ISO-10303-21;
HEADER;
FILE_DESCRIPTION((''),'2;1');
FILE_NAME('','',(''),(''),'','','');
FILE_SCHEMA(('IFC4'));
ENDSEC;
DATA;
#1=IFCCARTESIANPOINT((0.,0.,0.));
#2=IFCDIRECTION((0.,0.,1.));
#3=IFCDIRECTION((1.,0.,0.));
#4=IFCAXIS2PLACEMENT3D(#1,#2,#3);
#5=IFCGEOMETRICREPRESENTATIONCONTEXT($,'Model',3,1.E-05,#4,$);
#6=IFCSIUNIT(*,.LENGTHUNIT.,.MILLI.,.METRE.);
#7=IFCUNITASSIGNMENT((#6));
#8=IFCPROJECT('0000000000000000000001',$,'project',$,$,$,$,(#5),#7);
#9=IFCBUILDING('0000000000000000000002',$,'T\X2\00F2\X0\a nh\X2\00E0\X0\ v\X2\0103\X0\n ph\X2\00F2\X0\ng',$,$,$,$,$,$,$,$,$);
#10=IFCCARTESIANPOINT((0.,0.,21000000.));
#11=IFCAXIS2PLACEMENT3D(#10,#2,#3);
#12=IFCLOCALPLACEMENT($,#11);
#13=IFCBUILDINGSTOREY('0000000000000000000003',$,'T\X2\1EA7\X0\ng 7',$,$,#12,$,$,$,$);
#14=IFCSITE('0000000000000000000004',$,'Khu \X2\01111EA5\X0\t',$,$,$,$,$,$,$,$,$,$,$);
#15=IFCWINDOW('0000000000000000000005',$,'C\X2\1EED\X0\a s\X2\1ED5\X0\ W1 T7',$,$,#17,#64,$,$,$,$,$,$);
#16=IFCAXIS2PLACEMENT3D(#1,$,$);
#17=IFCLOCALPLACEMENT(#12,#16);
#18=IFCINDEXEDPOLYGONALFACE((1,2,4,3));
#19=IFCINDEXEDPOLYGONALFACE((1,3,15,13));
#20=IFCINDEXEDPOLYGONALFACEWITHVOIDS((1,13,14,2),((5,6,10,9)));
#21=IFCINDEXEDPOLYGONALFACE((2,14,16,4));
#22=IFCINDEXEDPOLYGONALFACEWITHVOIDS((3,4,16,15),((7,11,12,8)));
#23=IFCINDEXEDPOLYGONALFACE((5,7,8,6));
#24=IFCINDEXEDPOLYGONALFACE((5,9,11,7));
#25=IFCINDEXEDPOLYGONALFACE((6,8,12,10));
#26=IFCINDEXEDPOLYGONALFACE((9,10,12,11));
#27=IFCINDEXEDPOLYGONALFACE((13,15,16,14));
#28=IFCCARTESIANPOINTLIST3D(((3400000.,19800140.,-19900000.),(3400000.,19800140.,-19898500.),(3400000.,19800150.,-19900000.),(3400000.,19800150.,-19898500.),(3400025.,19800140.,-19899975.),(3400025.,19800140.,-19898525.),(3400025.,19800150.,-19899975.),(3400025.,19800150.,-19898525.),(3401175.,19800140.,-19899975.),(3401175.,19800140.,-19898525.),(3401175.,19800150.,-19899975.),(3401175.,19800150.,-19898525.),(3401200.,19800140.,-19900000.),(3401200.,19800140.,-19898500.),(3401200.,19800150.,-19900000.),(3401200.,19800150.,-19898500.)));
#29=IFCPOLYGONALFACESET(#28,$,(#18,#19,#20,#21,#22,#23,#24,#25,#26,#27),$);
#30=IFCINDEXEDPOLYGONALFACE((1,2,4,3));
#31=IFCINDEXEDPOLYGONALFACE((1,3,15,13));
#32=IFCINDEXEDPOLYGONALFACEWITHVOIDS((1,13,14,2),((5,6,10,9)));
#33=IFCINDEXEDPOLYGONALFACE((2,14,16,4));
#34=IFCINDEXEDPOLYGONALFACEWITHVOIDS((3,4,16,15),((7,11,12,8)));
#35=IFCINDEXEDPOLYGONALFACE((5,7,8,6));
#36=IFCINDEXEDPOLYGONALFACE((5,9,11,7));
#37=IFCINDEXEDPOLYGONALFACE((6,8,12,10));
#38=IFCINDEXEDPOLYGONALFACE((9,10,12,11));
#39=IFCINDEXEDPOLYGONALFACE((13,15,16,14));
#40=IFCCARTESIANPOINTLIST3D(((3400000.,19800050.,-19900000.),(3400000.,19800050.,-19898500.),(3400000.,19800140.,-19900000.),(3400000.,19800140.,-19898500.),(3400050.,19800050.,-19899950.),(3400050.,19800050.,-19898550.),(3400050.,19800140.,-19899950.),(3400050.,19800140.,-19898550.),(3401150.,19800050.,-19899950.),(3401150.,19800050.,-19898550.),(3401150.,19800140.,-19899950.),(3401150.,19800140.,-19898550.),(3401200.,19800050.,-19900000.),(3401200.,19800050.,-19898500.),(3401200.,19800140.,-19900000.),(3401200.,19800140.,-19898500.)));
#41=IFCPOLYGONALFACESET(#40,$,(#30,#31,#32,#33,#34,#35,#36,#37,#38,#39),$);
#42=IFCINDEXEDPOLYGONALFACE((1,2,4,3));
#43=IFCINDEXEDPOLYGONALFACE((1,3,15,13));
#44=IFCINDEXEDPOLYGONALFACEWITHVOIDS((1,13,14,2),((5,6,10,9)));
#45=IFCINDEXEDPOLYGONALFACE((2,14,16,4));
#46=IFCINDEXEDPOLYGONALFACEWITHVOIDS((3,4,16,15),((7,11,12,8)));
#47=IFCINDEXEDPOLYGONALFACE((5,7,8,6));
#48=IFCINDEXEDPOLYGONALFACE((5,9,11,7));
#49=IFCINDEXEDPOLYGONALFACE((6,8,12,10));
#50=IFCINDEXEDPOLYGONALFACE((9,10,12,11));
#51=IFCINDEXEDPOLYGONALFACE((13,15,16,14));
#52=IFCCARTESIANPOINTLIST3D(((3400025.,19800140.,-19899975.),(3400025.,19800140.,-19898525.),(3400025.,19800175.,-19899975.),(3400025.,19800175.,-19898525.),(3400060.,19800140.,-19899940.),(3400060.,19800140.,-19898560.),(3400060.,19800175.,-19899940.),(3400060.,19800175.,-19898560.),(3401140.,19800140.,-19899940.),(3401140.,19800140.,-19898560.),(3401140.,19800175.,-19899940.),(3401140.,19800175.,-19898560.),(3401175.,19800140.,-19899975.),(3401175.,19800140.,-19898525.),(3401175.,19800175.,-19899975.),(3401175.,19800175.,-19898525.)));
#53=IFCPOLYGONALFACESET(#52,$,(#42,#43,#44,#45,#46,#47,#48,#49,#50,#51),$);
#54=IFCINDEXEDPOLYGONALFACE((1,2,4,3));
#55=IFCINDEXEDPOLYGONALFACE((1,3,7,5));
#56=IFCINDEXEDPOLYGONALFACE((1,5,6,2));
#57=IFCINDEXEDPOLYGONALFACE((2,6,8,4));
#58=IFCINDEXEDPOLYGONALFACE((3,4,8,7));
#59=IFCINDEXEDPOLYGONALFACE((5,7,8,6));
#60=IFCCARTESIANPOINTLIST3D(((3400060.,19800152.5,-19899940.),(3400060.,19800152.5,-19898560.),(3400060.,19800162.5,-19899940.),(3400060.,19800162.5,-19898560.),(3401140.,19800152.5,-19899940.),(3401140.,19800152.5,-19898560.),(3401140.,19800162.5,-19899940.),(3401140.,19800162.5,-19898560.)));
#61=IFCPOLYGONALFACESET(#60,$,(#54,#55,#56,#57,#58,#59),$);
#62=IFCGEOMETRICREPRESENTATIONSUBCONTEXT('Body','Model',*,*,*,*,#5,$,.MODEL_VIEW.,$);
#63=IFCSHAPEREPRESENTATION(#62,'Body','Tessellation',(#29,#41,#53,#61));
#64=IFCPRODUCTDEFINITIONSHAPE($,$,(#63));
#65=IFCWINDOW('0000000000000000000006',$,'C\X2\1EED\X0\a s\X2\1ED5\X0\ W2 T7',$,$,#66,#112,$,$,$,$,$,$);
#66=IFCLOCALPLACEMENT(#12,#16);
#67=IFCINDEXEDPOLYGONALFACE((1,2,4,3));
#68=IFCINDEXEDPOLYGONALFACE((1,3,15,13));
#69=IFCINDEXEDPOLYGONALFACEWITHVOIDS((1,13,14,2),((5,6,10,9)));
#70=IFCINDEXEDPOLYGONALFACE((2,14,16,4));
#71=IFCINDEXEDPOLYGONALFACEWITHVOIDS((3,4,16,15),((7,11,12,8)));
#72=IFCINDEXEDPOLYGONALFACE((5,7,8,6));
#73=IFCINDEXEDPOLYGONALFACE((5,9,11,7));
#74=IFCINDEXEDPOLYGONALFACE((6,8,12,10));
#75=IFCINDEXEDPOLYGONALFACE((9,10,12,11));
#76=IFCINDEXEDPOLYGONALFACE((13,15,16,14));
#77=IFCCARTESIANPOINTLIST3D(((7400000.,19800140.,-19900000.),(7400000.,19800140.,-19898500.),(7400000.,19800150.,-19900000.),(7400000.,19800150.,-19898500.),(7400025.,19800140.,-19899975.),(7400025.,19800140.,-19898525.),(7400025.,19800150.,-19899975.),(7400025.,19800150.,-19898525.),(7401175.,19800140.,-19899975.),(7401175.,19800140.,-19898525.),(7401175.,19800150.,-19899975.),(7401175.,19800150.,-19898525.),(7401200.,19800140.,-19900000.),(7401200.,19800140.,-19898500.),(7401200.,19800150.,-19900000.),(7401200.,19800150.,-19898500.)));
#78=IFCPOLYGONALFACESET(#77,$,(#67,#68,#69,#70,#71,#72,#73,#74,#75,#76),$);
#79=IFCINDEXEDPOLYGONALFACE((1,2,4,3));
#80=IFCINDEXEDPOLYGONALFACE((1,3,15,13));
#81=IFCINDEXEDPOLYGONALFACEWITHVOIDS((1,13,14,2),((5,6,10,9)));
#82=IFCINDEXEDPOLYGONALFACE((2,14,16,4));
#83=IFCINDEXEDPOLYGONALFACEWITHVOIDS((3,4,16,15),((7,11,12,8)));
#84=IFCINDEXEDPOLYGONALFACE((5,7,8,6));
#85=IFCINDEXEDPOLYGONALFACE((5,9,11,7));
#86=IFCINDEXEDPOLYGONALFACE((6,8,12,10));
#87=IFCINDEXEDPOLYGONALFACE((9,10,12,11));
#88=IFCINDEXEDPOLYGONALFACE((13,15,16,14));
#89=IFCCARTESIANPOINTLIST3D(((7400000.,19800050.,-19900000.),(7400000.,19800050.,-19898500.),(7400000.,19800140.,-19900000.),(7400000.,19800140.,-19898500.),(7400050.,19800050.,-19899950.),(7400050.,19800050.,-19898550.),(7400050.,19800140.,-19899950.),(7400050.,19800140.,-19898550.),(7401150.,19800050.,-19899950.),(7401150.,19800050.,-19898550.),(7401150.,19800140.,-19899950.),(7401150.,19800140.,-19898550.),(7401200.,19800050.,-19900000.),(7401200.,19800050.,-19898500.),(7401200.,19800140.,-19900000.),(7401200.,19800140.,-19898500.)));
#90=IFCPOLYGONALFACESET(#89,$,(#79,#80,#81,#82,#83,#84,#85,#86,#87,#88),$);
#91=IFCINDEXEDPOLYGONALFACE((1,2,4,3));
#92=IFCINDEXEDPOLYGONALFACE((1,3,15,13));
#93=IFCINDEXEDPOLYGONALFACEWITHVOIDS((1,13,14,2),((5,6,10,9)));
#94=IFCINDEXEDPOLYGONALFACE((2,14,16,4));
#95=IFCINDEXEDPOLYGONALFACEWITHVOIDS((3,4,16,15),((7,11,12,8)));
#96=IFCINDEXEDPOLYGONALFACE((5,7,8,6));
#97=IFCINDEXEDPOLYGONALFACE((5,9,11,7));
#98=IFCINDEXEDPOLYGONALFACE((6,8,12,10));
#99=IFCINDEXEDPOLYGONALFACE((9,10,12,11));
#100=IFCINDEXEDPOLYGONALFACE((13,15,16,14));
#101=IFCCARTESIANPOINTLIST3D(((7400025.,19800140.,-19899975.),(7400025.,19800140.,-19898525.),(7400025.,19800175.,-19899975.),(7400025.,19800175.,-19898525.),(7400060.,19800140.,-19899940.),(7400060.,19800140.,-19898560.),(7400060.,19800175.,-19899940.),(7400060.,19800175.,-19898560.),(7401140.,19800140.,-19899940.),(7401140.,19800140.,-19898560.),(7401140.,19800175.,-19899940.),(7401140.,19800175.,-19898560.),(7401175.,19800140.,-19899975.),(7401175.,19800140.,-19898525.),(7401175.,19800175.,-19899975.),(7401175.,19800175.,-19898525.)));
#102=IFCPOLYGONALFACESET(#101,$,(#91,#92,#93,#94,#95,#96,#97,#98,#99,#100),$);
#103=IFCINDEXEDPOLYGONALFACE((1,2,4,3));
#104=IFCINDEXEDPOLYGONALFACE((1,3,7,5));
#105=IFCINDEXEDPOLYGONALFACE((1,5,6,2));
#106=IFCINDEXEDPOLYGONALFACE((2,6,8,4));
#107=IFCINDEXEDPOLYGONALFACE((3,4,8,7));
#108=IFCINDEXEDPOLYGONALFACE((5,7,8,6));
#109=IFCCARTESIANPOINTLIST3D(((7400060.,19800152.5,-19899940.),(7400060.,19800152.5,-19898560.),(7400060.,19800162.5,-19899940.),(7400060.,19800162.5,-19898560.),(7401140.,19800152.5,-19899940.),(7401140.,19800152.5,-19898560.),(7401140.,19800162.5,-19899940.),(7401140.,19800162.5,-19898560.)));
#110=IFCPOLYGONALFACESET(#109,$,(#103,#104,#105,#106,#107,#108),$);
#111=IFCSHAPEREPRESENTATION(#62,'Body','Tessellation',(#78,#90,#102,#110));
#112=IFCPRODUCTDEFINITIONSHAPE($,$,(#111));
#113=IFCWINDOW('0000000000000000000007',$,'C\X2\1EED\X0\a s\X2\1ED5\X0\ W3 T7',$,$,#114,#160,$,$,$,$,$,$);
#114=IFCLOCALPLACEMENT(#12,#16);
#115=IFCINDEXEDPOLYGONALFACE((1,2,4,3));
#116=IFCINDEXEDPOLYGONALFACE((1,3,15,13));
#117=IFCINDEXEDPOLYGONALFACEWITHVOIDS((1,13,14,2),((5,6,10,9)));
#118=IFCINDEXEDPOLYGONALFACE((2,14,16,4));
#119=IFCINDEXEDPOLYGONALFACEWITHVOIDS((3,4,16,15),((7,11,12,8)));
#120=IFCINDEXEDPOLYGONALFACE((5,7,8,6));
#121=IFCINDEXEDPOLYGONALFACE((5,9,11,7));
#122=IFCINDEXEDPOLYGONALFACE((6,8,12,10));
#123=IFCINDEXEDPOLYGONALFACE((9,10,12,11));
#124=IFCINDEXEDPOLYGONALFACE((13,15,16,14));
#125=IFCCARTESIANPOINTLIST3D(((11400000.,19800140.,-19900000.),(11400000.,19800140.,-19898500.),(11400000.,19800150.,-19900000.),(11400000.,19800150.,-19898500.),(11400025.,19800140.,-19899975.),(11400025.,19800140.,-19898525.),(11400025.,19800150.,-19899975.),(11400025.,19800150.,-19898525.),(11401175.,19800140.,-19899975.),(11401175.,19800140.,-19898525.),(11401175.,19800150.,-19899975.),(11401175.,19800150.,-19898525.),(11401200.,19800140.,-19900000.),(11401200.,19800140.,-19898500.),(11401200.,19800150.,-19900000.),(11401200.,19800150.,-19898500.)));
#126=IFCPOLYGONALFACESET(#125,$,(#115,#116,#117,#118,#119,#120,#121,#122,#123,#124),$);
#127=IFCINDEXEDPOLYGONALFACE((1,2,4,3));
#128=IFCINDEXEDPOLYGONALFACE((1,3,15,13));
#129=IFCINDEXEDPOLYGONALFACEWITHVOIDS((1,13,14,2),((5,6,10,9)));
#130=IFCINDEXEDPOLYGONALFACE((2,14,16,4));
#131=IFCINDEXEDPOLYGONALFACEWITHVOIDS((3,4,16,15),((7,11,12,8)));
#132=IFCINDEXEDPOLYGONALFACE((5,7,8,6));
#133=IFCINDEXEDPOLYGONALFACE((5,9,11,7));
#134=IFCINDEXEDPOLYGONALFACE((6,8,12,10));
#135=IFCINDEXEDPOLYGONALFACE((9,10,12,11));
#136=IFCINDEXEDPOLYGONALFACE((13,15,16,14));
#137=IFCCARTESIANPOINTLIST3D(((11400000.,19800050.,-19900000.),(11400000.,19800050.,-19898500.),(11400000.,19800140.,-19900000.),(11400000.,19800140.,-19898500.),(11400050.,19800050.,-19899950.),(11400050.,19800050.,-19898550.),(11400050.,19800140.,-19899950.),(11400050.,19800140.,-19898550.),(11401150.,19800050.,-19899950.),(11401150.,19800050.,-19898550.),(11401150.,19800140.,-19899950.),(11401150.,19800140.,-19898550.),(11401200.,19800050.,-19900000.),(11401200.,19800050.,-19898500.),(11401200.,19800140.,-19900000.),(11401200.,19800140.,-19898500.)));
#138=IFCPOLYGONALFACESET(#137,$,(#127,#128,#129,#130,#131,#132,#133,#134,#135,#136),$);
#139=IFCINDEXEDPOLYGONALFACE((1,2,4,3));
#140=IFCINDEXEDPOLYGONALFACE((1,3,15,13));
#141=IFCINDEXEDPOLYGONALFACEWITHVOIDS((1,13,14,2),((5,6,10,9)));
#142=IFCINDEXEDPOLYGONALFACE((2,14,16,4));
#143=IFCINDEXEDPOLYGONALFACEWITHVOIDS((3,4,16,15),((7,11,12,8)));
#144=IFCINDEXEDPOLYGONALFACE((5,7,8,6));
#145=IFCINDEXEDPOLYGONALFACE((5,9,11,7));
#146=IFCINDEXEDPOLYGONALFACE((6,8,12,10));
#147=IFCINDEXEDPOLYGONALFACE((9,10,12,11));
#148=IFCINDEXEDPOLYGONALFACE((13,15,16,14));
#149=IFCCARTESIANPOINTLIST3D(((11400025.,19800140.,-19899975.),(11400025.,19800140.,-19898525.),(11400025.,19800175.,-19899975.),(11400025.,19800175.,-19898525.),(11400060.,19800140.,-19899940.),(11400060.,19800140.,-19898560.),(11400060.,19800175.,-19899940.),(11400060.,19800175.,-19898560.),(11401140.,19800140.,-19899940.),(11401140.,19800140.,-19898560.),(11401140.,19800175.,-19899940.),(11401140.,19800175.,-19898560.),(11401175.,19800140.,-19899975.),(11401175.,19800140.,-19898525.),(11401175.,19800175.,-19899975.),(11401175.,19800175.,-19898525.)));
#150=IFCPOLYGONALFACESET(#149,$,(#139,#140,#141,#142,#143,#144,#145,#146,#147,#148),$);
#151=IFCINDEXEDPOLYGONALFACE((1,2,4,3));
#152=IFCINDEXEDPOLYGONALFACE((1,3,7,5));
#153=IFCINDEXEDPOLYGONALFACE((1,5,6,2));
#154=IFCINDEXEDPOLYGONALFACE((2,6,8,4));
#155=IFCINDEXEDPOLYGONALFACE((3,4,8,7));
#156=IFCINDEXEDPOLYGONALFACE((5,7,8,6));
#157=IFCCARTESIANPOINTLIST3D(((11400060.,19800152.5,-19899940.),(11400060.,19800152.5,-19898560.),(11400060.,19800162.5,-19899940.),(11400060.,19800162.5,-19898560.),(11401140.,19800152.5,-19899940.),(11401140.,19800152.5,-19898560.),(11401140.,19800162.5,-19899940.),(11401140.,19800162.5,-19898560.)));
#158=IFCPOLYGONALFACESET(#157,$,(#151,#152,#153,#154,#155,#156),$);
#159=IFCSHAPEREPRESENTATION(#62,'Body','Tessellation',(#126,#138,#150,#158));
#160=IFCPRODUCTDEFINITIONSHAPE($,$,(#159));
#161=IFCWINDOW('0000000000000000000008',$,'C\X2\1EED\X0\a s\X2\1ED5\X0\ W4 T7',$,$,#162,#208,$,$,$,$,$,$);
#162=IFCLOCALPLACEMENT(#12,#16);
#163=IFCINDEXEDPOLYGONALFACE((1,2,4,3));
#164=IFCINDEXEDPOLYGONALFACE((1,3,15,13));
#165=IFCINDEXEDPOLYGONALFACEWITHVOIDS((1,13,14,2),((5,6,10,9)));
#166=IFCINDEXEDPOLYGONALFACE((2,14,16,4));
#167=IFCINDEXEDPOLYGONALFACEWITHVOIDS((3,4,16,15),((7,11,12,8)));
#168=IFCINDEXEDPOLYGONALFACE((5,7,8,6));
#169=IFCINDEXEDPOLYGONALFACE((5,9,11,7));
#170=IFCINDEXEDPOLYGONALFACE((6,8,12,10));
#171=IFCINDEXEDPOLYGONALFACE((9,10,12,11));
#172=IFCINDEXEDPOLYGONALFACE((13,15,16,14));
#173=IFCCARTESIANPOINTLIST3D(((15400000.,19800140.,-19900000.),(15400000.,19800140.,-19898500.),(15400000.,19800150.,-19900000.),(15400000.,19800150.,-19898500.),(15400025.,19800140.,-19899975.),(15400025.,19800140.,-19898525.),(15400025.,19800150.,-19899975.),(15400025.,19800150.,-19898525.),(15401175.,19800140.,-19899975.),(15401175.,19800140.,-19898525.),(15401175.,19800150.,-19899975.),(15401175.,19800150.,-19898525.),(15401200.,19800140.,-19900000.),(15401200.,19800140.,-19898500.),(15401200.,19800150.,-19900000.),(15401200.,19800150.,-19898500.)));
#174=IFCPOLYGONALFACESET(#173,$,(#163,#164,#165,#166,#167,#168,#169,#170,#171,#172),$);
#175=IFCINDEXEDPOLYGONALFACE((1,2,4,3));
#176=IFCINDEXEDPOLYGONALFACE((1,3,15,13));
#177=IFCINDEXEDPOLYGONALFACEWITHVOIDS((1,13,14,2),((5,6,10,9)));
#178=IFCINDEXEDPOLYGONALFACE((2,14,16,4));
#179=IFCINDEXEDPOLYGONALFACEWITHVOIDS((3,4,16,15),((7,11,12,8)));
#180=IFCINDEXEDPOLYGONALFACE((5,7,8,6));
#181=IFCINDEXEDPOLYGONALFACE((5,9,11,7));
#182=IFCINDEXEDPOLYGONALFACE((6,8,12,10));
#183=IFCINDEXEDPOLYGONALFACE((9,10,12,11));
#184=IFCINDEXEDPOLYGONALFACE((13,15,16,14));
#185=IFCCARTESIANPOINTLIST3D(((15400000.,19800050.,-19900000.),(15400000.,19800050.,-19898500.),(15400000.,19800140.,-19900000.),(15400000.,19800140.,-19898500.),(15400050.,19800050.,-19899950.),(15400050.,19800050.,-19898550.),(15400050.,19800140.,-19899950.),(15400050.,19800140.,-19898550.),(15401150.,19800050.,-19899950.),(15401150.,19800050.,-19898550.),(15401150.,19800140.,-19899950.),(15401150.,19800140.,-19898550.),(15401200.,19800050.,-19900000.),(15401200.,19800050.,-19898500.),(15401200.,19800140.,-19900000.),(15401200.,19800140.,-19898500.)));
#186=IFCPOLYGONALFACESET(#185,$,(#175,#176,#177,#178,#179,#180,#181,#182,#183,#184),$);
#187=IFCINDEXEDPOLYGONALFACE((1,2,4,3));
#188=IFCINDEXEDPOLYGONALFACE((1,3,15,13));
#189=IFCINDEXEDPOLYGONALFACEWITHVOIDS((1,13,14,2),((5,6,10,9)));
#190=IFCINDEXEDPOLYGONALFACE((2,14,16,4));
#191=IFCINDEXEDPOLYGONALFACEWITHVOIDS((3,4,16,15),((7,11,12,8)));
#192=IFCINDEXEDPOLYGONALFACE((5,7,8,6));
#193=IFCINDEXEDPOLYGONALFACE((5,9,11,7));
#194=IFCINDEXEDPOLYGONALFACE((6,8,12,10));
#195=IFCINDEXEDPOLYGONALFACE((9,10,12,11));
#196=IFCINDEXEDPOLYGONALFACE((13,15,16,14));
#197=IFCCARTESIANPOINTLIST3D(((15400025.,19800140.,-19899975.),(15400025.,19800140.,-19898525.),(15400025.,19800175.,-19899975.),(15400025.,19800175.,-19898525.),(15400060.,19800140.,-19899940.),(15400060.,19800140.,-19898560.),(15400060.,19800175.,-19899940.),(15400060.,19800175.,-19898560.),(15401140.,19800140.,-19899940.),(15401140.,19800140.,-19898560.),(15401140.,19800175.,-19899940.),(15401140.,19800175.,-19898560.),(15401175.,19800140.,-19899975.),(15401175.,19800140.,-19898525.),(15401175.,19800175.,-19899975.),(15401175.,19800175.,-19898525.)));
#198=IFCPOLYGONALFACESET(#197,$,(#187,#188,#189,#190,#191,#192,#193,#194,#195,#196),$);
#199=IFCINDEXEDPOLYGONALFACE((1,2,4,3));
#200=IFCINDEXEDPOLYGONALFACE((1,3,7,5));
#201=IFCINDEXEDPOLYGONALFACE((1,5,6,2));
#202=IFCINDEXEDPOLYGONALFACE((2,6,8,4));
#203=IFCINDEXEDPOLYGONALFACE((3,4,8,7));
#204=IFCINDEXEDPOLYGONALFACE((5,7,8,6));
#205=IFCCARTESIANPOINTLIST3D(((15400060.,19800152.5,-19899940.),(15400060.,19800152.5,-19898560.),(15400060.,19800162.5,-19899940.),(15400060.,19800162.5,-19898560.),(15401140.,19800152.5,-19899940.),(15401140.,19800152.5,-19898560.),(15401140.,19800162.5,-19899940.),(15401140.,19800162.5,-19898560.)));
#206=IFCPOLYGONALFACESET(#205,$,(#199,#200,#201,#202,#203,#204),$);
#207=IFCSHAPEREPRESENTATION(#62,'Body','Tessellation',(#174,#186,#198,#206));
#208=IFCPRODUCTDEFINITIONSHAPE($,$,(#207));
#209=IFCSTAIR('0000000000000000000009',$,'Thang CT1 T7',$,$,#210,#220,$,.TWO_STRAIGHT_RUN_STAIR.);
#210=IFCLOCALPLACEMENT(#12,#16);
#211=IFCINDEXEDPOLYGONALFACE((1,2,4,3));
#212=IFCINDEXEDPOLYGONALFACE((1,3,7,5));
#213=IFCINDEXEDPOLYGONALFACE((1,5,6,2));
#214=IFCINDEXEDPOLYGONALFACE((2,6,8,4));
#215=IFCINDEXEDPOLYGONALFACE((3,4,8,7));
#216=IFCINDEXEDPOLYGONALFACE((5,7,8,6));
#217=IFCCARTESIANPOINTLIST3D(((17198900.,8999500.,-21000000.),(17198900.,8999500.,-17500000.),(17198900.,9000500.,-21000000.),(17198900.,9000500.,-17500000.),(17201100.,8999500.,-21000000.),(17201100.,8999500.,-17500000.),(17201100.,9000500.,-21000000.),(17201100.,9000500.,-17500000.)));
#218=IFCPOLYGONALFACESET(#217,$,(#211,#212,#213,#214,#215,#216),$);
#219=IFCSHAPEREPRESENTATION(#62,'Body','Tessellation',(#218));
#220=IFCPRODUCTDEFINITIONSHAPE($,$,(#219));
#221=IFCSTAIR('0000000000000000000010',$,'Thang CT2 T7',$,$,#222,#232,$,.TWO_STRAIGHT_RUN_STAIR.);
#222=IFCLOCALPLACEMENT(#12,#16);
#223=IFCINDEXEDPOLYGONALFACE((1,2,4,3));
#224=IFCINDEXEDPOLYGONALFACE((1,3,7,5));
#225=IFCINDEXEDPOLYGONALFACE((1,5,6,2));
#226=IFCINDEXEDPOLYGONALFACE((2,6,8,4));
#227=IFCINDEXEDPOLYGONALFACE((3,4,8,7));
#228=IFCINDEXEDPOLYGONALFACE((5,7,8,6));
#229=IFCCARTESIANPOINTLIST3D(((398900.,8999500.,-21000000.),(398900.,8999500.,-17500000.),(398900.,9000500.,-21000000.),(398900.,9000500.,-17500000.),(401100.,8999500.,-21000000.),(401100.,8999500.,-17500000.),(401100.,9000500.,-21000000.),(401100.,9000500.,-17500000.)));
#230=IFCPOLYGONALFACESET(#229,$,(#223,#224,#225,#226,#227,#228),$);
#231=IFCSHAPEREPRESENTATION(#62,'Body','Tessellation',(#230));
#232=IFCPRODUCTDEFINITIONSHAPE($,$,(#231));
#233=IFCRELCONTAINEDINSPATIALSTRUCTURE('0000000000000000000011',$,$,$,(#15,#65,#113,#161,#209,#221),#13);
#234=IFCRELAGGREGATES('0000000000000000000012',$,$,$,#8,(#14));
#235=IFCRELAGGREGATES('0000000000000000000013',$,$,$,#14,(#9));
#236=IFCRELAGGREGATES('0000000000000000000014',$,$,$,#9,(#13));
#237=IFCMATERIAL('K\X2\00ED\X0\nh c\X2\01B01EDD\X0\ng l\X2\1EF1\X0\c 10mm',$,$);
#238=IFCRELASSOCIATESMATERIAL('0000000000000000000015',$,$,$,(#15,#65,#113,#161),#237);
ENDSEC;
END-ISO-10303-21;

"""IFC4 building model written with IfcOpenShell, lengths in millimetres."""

from ifc_helpers import new_model, entity, si_unit, frame, origin_with_axes, place, context, subcontext, project, spatial, line, indexed_curve, outline, extrude, material, element, save


model = new_model("IFC4")

# Units and contexts
model_context = context("Model", 3, precision=1e-05, world=origin_with_axes())
body_context = subcontext(model_context, "Body", "Model", "MODEL_VIEW")
ifc_project = project(units=[si_unit("LENGTHUNIT", "METRE", prefix="MILLI")], contexts=[model_context])

# Site, building, storey
site = spatial("IfcSite", under=ifc_project, Name="Khu đất")
building = spatial("IfcBuilding", under=site, Name="Tòa nhà văn phòng")
storey_placement = place(None, frame((0.0, 0.0, 21000000.0), z_axis=(0.0, 0.0, 1.0), x_axis=(1.0, 0.0, 0.0)))
storey = spatial("IfcBuildingStorey", under=building, at=storey_placement, Name="Tầng 7")

# Windows
ifc_material_1 = material(Name="Kính cường lực 10mm")
for number, where, z_axis, x_axis, name in (
    (1, (3400000.0, 19800000.0, -19900000.0), (0.0, 0.0, 1.0), (1.0, 0.0, 0.0), "Cửa sổ W1 T7"),
    (2, (7400000.0, 19800000.0, -19900000.0), (0.0, 0.0, 1.0), (1.0, 0.0, 0.0), "Cửa sổ W2 T7"),
    (3, (11400000.0, 19800000.0, -19900000.0), (0.0, 0.0, 1.0), (1.0, 0.0, 0.0), "Cửa sổ W3 T7"),
    (4, (15400000.0, 19800000.0, -19900000.0), (0.0, 0.0, 1.0), (1.0, 0.0, 0.0), "Cửa sổ W4 T7"),
):
    element("IfcWindow", number, at=place(storey_placement, frame(where, z_axis=z_axis, x_axis=x_axis)), inside=storey, material=ifc_material_1, Name=name, context=body_context, shape_type="SolidModel", body=[
        extrude(outline(indexed_curve([(0.0, 0.0), (1200.0, 0.0), (1200.0, 1500.0), (0.0, 1500.0)], segments=[line(1, 2, 3, 4, 1)]), holes=[indexed_curve([(25.0, 25.0), (1175.0, 25.0), (1175.0, 1475.0), (25.0, 1475.0)], segments=[line(1, 2, 3, 4, 1)])]), frame((0.0, 140.0, 0.0), z_axis=(0.0, -1.0, 0.0), x_axis=(1.0, 0.0, 0.0)), (0.0, 0.0, -1.0), 10.0),
        extrude(outline(indexed_curve([(0.0, 0.0), (1200.0, 0.0), (1200.0, 1500.0), (0.0, 1500.0)], segments=[line(1, 2, 3, 4, 1)]), holes=[indexed_curve([(50.0, 50.0), (1150.0, 50.0), (1150.0, 1450.0), (50.0, 1450.0)], segments=[line(1, 2, 3, 4, 1)])]), frame((0.0, 50.0, 0.0), z_axis=(0.0, -1.0, 0.0), x_axis=(1.0, 0.0, 0.0)), (0.0, 0.0, -1.0), 90.0),
        extrude(outline(indexed_curve([(0.0, 0.0), (1150.0, 0.0), (1150.0, 1450.0), (0.0, 1450.0)], segments=[line(1, 2, 3, 4, 1)]), holes=[indexed_curve([(35.0, 35.0), (1115.0, 35.0), (1115.0, 1415.0), (35.0, 1415.0)], segments=[line(1, 2, 3, 4, 1)])]), frame((25.0, 140.0, 25.0), z_axis=(0.0, -1.0, 0.0), x_axis=(1.0, 0.0, 0.0)), (0.0, 0.0, -1.0), 35.0),
        extrude(outline(indexed_curve([(35.0, 35.0), (1115.0, 35.0), (1115.0, 1415.0), (35.0, 1415.0)], segments=[line(1, 2, 3, 4, 1)])), frame((25.0, 152.5, 25.0), z_axis=(0.0, -1.0, 0.0), x_axis=(1.0, 0.0, 0.0)), (0.0, 0.0, -1.0), 10.0),
    ])

# Stairs
for number, where, z_axis, x_axis, name in (
    (5, (17200000.0, 9000000.0, -21000000.0), (0.0, 0.0, 1.0), (1.0, 0.0, 0.0), "Thang CT1 T7"),
    (6, (400000.0, 9000000.0, -21000000.0), (0.0, 0.0, 1.0), (1.0, 0.0, 0.0), "Thang CT2 T7"),
):
    element("IfcStair", number, at=place(storey_placement, frame(where, z_axis=z_axis, x_axis=x_axis)), inside=storey, Name=name, PredefinedType="TWO_STRAIGHT_RUN_STAIR", context=body_context, shape_type="SweptSolid", body=[
        extrude(entity("IfcRectangleProfileDef", None, None, None, 2200.0, 1000.0), origin_with_axes(), (0.0, 0.0, 1.0), 3500000.0),
    ])

save(model, "model.ifc")
